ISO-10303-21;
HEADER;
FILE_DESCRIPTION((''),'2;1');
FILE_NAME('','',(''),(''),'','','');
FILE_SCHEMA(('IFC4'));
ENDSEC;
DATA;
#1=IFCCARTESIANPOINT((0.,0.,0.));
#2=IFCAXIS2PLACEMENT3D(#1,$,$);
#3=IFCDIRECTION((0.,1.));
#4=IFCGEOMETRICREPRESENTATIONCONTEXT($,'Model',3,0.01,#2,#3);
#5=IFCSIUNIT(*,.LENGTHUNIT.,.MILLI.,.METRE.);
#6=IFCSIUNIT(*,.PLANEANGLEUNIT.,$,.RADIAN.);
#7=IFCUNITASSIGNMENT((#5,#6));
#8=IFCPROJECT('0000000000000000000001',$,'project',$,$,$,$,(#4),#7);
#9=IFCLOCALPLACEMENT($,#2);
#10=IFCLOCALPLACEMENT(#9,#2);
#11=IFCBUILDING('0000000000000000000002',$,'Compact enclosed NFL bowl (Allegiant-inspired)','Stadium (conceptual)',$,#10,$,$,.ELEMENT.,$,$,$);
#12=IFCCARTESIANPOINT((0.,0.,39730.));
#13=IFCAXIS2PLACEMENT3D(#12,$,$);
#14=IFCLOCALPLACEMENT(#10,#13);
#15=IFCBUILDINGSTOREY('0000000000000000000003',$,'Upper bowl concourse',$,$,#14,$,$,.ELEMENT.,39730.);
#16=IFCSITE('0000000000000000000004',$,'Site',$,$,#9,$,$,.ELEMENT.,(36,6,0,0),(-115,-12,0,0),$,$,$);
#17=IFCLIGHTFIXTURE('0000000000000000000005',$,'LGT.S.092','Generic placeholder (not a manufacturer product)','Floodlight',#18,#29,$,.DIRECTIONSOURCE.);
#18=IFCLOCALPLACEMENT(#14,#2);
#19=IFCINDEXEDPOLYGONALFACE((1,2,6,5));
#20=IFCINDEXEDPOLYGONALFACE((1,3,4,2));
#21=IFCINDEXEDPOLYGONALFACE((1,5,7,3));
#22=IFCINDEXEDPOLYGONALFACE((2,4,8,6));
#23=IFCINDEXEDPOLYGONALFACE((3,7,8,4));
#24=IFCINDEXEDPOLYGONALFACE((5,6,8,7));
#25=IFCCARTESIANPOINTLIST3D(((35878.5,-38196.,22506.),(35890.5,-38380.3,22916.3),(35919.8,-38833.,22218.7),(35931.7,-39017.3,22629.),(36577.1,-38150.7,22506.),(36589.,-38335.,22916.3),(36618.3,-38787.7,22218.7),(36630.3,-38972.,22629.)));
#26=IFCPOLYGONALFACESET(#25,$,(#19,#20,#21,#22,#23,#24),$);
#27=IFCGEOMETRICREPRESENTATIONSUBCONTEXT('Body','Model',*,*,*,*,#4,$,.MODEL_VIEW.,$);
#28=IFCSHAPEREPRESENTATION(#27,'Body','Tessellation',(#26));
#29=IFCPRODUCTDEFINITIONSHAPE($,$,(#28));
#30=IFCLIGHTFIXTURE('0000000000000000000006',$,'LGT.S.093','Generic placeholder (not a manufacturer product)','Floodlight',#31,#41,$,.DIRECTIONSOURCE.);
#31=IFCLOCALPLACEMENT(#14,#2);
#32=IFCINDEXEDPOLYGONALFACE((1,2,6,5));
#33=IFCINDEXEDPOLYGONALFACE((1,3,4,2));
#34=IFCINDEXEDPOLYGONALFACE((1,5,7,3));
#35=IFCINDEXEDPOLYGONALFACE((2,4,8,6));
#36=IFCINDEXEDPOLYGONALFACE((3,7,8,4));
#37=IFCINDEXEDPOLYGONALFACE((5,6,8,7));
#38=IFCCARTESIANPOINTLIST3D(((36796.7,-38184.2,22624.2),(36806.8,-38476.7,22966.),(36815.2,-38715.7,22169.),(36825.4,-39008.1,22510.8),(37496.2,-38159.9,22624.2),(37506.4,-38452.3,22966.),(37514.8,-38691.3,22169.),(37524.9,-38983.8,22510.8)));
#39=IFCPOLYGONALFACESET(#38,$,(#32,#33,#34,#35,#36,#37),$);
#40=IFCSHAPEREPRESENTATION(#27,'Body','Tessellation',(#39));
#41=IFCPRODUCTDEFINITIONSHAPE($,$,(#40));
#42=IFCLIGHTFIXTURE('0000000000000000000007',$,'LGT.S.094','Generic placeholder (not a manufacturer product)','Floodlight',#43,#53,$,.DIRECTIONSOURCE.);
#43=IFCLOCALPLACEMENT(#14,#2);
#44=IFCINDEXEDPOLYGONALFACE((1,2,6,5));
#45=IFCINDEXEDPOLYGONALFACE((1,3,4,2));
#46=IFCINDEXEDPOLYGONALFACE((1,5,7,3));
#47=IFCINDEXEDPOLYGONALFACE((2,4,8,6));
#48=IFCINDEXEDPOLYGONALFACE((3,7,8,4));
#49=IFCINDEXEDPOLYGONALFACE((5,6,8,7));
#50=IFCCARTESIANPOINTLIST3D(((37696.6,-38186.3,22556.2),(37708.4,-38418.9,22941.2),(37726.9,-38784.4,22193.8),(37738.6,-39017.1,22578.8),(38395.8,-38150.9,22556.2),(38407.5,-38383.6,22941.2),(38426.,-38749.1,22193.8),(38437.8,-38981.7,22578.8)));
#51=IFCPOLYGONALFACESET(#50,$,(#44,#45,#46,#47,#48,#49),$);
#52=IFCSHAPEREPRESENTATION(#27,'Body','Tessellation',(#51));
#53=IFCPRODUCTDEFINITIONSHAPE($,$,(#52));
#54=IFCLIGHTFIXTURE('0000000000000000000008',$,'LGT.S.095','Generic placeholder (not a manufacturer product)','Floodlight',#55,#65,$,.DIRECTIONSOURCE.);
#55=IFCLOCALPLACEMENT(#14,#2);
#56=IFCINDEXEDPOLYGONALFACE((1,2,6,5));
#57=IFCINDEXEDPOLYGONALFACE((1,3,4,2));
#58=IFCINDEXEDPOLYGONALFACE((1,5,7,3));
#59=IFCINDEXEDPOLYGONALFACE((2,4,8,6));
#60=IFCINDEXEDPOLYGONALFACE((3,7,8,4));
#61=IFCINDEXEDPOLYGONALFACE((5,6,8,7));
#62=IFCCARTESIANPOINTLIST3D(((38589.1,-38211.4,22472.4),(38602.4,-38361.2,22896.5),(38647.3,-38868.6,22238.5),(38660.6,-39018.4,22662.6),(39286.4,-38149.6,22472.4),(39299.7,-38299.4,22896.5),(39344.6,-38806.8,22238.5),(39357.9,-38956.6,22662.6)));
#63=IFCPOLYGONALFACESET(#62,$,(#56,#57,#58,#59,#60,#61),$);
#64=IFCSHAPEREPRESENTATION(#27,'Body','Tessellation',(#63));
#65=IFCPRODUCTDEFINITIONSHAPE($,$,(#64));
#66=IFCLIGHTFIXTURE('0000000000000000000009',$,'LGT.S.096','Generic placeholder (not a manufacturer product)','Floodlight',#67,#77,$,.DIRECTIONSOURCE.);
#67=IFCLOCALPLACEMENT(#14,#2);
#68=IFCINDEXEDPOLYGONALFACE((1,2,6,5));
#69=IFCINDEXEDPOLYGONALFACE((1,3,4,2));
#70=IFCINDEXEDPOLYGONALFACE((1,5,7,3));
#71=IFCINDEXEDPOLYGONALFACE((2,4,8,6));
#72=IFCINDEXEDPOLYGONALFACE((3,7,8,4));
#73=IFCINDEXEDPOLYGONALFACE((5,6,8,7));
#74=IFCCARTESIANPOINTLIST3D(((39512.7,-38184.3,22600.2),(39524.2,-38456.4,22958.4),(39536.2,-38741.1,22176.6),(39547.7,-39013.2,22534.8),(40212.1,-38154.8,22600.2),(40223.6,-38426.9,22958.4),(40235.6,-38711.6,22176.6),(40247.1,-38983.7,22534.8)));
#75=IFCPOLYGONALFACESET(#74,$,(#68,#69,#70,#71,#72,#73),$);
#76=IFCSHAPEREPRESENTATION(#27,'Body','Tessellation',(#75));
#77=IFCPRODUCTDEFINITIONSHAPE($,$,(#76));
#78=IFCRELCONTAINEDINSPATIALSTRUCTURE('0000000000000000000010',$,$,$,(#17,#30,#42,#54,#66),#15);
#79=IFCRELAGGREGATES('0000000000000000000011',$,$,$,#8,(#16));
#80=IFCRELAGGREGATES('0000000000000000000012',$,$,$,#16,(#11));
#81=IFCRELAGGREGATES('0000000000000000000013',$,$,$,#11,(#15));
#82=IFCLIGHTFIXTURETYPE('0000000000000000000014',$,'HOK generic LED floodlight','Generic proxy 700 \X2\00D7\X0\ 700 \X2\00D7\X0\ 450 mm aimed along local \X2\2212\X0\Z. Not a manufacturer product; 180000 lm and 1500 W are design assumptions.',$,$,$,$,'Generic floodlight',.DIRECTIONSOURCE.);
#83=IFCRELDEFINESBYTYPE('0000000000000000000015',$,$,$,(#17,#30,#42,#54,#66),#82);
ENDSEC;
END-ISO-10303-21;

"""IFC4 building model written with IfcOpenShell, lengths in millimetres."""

from ifc_helpers import new_model, si_unit, direction, frame, origin, place, context, subcontext, project, spatial, rectangle, extrude, source, transform, mapped, type_object, type_shapes, element, save


model = new_model("IFC4")

# Units and contexts
model_context = context("Model", 3, precision=0.01, world=origin(), true_north=direction((0.0, 1.0)))
body_context = subcontext(model_context, "Body", "Model", "MODEL_VIEW")
ifc_project = project(units=[si_unit("LENGTHUNIT", "METRE", prefix="MILLI"), si_unit("PLANEANGLEUNIT", "RADIAN")], contexts=[model_context])

# Site, building, storey
site_placement = place(None, origin())
site = spatial("IfcSite", under=ifc_project, at=site_placement, Name="Site", CompositionType="ELEMENT", RefLatitude=(36, 6, 0, 0), RefLongitude=(-115, -12, 0, 0))
building_placement = place(site_placement, origin())
building = spatial("IfcBuilding", under=site, at=building_placement, Name="Compact enclosed NFL bowl (Allegiant-inspired)", Description="Stadium (conceptual)", CompositionType="ELEMENT")
storey_placement = place(building_placement, frame((0.0, 0.0, 39730.0)))
storey = spatial("IfcBuildingStorey", under=building, at=storey_placement, Name="Upper bowl concourse", CompositionType="ELEMENT", Elevation=39730.0)

# Light fixtures
light_fixture_type = type_object("IfcLightFixtureType", Name="HOK generic LED floodlight", Description="Generic proxy 700 × 700 × 450 mm aimed along local −Z. Not a manufacturer product; 180000 lm and 1500 W are design assumptions.", ElementType="Generic floodlight", PredefinedType="DIRECTIONSOURCE")
shared_shape = source(origin(), body_context, "Body", "SweptSolid", [
    extrude(rectangle(XDim=700.0, YDim=700.0), frame((0.0, 0.0, -225.0)), (0.0, 0.0, 1.0), 450.0),
])
type_shapes(light_fixture_type, [shared_shape])
for number, where, z_axis, x_axis, name in (
    (1, (36254.4, -38584.0, 22567.5), (0.026535, -0.409538, 0.911907), (0.997908, 0.064656, 0.0), "LGT.S.092"),
    (2, (37160.8, -38584.0, 22567.5), (0.022658, -0.649906, 0.759677), (0.999393, 0.034842, 0.0), "LGT.S.093"),
    (3, (38067.2, -38584.0, 22567.5), (0.02614, -0.517043, 0.85556), (0.998724, 0.050492, 0.0), "LGT.S.094"),
    (4, (38973.5, -38584.0, 22567.5), (0.029482, -0.332861, 0.942515), (0.9961, 0.088226, 0.0), "LGT.S.095"),
    (5, (39879.9, -38584.0, 22567.5), (0.02548, -0.604667, 0.796071), (0.999113, 0.042102, 0.0), "LGT.S.096"),
):
    element("IfcLightFixture", number, at=place(storey_placement, frame(where, z_axis=z_axis, x_axis=x_axis)), inside=storey, type_object=light_fixture_type, Name=name, Description="Generic placeholder (not a manufacturer product)", ObjectType="Floodlight", PredefinedType="DIRECTIONSOURCE", context=body_context, shape_type="MappedRepresentation", body=[
        mapped(shared_shape, transform((0.0, 0.0, 0.0))),
    ])

save(model, "model.ifc")
